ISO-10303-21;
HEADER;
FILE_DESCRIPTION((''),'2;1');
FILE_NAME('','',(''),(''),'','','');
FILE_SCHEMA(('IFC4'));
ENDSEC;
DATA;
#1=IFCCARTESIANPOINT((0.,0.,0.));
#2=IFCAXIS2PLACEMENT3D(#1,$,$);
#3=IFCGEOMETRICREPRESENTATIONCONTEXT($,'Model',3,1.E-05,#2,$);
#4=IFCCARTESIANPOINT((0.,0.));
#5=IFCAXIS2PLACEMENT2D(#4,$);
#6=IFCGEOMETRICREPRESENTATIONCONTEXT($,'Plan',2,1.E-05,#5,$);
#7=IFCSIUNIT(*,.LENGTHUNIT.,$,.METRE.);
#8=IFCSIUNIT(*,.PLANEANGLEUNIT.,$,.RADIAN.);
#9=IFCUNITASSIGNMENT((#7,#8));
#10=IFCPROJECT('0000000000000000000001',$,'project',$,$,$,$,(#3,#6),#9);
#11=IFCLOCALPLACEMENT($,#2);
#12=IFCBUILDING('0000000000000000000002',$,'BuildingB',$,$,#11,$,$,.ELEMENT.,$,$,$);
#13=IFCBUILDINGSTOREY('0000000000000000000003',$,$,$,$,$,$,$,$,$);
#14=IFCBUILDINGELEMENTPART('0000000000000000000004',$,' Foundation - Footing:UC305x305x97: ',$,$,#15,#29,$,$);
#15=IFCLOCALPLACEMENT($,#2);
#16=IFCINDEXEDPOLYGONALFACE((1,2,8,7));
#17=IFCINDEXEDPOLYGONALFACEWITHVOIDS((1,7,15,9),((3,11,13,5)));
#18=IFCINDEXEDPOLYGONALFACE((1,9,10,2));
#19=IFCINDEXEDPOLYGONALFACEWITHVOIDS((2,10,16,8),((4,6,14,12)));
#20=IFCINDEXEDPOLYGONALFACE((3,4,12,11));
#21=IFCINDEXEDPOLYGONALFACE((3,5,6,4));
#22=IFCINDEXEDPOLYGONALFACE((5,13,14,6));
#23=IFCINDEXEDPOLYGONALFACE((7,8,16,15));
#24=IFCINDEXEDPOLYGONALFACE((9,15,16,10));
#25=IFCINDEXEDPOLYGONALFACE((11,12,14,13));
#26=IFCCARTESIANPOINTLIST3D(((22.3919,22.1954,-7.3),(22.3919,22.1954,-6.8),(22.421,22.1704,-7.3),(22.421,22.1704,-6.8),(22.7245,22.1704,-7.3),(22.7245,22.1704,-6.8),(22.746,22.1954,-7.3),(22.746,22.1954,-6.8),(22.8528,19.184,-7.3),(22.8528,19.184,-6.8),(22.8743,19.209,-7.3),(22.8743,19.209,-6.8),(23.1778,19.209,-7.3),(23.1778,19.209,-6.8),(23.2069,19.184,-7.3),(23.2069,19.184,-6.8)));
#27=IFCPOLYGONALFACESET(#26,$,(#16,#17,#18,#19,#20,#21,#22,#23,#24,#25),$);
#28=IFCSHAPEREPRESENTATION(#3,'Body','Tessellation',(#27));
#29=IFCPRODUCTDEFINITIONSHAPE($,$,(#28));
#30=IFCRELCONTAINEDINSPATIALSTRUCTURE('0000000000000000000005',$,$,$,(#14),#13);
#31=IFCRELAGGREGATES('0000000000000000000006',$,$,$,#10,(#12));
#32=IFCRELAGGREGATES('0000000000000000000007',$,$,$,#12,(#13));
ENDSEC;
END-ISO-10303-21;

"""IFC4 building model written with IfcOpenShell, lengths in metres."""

from ifc_helpers import new_model, si_unit, origin, origin_2d, place, context, project, spatial, polyline, outline, extrude, element, save


model = new_model("IFC4")

# Units and contexts
model_context = context("Model", 3, precision=1e-05, world=origin())
plan_context = context("Plan", 2, precision=1e-05, world=origin_2d())
ifc_project = project(units=[si_unit("LENGTHUNIT", "METRE"), si_unit("PLANEANGLEUNIT", "RADIAN")], contexts=[model_context, plan_context])

# Building, storey
building_placement = place(None, origin())
building = spatial("IfcBuilding", under=ifc_project, at=building_placement, Name="BuildingB", CompositionType="ELEMENT")
storey = spatial("IfcBuildingStorey", under=building)

# Building element part, opening
building_element_part_1 = element("IfcBuildingElementPart", 1, inside=storey, Name=" Foundation - Footing:UC305x305x97: ", context=model_context, shape_type="SweptSolid", body=[
    extrude(outline(polyline([(22.8528, 19.184, -7.3), (23.2069, 19.184, -7.3), (22.746, 22.1954, -7.3), (22.3919, 22.1954, -7.3), (22.8528, 19.184, -7.3)])), None, (0.0, 0.0, 1.0), 0.5),
])
element("IfcOpeningElement", 2, inside=storey, cuts=building_element_part_1, context=model_context, shape_type="SweptSolid", body=[
    extrude(outline(polyline([(22.8743, 19.209, -7.3), (23.1778, 19.209, -7.3), (22.7245, 22.1704, -7.3), (22.421, 22.1704, -7.3), (22.8743, 19.209, -7.3)])), None, (0.0, 0.0, 1.0), 0.5),
])

save(model, "model.ifc")
